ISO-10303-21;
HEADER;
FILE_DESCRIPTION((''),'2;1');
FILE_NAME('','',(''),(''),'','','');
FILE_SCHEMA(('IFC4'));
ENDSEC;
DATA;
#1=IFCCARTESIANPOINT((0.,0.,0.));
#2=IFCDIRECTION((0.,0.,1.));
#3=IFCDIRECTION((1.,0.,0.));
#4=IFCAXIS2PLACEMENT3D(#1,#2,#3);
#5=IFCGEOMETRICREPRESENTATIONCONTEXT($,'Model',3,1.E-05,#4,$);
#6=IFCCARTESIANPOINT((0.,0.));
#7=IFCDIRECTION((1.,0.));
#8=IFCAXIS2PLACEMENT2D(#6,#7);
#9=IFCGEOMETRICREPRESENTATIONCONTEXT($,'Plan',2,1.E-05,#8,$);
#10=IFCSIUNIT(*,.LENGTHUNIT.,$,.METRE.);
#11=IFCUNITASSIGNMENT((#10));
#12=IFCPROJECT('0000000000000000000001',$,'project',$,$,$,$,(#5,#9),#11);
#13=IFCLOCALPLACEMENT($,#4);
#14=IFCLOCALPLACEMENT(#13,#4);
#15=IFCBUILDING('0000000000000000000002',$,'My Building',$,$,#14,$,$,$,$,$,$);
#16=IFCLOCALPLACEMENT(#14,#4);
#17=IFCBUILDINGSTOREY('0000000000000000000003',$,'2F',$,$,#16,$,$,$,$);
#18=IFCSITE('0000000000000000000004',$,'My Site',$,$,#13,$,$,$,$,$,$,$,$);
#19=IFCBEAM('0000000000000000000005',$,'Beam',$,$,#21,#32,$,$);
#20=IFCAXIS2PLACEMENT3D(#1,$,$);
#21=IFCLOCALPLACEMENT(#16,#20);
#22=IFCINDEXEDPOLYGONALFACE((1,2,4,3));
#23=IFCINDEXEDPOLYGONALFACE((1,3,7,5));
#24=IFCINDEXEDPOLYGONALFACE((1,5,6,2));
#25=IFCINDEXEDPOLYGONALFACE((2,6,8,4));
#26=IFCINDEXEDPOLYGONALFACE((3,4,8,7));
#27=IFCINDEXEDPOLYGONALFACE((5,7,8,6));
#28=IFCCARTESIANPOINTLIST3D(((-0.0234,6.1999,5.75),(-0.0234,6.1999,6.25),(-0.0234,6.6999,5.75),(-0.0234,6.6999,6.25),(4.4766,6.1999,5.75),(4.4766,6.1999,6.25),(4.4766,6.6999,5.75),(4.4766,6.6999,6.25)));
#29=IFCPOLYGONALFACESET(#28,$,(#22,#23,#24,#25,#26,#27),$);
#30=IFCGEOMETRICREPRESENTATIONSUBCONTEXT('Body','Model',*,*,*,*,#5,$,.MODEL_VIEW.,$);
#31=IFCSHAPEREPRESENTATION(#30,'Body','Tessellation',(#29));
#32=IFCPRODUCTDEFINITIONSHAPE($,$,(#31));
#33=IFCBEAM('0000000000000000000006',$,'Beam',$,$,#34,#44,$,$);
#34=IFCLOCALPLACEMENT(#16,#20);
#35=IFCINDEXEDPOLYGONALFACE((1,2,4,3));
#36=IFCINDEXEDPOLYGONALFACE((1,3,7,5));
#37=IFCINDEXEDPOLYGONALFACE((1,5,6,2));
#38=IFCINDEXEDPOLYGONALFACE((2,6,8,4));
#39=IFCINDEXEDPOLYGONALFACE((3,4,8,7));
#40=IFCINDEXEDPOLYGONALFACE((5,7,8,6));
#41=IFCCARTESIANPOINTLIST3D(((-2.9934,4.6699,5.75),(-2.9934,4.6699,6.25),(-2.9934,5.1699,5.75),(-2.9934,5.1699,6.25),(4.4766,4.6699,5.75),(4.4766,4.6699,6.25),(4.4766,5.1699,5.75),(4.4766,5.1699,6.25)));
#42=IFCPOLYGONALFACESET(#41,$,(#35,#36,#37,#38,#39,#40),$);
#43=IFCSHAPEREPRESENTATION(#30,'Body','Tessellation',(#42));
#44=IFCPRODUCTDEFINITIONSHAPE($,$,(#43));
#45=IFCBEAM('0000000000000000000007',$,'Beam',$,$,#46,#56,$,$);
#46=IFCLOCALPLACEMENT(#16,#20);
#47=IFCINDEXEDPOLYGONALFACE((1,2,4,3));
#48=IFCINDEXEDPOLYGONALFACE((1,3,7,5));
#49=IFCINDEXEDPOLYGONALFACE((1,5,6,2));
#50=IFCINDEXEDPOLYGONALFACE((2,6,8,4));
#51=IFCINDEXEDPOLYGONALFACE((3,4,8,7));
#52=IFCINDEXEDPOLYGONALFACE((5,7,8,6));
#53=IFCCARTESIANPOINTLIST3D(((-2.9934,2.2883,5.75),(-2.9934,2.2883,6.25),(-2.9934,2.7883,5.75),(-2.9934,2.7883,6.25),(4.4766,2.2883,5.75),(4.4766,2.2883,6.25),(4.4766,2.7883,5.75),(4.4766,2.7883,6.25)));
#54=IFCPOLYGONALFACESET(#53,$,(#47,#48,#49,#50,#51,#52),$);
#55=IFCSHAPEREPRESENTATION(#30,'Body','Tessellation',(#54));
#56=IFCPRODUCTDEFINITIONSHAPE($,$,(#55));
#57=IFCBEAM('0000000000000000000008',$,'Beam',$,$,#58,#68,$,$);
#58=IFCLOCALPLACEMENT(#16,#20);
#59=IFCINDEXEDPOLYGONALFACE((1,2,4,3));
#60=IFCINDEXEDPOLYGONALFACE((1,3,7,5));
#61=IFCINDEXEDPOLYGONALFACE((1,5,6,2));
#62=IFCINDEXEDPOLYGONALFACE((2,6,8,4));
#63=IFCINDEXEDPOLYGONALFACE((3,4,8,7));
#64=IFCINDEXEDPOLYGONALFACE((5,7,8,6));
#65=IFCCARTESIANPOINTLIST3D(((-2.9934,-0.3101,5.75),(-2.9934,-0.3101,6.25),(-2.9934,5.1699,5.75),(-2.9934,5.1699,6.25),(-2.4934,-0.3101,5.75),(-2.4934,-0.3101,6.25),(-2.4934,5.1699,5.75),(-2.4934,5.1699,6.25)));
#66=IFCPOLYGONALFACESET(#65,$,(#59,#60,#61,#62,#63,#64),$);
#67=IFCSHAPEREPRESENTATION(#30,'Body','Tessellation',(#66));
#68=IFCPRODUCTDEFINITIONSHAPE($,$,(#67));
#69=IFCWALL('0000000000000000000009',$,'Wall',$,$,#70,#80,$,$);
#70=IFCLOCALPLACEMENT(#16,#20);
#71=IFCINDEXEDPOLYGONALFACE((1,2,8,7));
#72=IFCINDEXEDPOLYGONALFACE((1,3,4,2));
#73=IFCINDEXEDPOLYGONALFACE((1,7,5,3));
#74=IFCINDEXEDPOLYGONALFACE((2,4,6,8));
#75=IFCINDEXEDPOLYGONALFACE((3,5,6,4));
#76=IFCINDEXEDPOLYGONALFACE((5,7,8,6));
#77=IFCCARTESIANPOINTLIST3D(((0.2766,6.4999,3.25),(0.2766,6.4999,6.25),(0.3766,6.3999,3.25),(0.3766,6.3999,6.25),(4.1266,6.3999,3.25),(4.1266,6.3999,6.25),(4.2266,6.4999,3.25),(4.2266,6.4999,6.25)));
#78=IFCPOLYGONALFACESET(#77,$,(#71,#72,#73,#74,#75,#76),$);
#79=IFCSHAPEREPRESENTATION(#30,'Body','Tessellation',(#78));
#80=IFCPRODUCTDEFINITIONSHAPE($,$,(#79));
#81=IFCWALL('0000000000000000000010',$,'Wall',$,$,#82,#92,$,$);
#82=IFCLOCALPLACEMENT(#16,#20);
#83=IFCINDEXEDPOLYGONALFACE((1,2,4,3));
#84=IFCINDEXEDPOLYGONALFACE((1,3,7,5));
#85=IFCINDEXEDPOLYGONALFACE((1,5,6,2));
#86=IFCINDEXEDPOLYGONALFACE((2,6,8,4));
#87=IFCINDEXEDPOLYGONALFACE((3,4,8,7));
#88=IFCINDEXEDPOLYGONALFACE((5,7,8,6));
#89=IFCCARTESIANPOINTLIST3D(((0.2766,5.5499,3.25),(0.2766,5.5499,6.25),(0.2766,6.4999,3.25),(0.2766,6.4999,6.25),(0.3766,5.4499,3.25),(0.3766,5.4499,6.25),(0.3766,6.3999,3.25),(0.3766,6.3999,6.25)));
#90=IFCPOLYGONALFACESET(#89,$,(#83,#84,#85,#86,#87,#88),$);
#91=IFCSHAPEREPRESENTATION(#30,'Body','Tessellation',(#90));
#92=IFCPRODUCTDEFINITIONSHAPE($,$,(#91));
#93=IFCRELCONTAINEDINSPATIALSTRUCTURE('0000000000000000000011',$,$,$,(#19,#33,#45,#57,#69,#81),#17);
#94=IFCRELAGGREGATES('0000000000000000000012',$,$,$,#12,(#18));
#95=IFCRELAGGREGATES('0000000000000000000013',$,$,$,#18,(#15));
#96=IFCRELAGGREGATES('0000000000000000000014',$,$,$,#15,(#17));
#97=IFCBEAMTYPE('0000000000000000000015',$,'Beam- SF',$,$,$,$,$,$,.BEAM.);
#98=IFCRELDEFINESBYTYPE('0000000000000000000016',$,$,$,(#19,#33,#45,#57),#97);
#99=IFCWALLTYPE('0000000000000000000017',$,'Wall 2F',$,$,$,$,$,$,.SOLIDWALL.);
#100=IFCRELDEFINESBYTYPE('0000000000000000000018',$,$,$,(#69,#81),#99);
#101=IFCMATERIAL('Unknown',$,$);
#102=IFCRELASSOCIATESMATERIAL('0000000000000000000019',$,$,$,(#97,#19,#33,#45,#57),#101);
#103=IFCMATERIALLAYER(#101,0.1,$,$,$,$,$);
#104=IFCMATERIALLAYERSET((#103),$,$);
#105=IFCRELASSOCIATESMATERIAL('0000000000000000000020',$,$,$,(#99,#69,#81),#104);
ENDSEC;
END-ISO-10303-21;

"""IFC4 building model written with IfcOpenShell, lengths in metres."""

from ifc_helpers import new_model, si_unit, frame, origin_with_axes, origin_2d_with_axis, place, context, subcontext, project, spatial, line, indexed_curve, rectangle, outline, extrude, material, layer, layer_set, layer_usage, material_profile, profile_set, profile_usage, type_object, element, save


model = new_model("IFC4")

# Units and contexts
model_context = context("Model", 3, precision=1e-05, world=origin_with_axes())
plan_context = context("Plan", 2, precision=1e-05, world=origin_2d_with_axis())
body_context_1 = subcontext(model_context, "Body", "Model", "MODEL_VIEW")
ifc_project = project(units=[si_unit("LENGTHUNIT", "METRE")], contexts=[model_context, plan_context])

# Site, building, storey
site_placement = place(None, origin_with_axes())
site = spatial("IfcSite", under=ifc_project, at=site_placement, Name="My Site")
building_placement = place(site_placement, origin_with_axes())
building = spatial("IfcBuilding", under=site, at=building_placement, Name="My Building")
storey_placement = place(building_placement, origin_with_axes())
storey = spatial("IfcBuildingStorey", under=building, at=storey_placement, Name="2F")

# Beams
ifc_material = material(Name="Unknown")
ifc_material_profile = material_profile(ifc_material, rectangle(XDim=0.5, YDim=0.5))
ifc_profile_set = profile_set([ifc_material_profile])
ifc_profile_usage_1 = profile_usage(ifc_profile_set, cardinal=5)
beam_type = type_object("IfcBeamType", Name="Beam- SF", PredefinedType="BEAM", material=ifc_profile_set)
beam_1_placement = place(storey_placement, frame((4.4766, 6.4499, 6.0), z_axis=(-1.0, -0.000001, 0.000001), x_axis=(0.000001, -1.0, 0.0)))
element("IfcBeam", 1, at=beam_1_placement, inside=storey, type_object=beam_type, material=ifc_profile_usage_1, Name="Beam", context=body_context_1, shape_type="SweptSolid", body=[
    extrude(rectangle(XDim=0.5, YDim=0.5), origin_with_axes(), (0.0, 0.0, 1.0), 4.5),
])
ifc_profile_usage_2 = profile_usage(ifc_profile_set, cardinal=5)
beam_2_placement = place(storey_placement, frame((4.4766, 4.9199, 6.0), z_axis=(-1.0, -0.000001, 0.000001), x_axis=(0.000001, -1.0, 0.0)))
element("IfcBeam", 2, at=beam_2_placement, inside=storey, type_object=beam_type, material=ifc_profile_usage_2, Name="Beam", context=body_context_1, shape_type="SweptSolid", body=[
    extrude(rectangle(XDim=0.5, YDim=0.5), origin_with_axes(), (0.0, 0.0, 1.0), 7.47),
])
ifc_profile_usage_3 = profile_usage(ifc_profile_set, cardinal=5)
beam_3_placement = place(storey_placement, frame((4.4766, 2.5383, 6.0), z_axis=(-1.0, -0.000001, 0.000001), x_axis=(0.000001, -1.0, 0.0)))
element("IfcBeam", 3, at=beam_3_placement, inside=storey, type_object=beam_type, material=ifc_profile_usage_3, Name="Beam", context=body_context_1, shape_type="SweptSolid", body=[
    extrude(rectangle(XDim=0.5, YDim=0.5), origin_with_axes(), (0.0, 0.0, 1.0), 7.47),
])
ifc_profile_usage_4 = profile_usage(ifc_profile_set, cardinal=5)
beam_4_placement = place(storey_placement, frame((-2.7434, 5.1699, 6.0), z_axis=(0.0, -1.0, 0.0), x_axis=(1.0, 0.0, 0.0)))
element("IfcBeam", 4, at=beam_4_placement, inside=storey, type_object=beam_type, material=ifc_profile_usage_4, Name="Beam", context=body_context_1, shape_type="SweptSolid", body=[
    extrude(rectangle(XDim=0.5, YDim=0.5), origin_with_axes(), (0.0, 0.0, 1.0), 5.48),
])

# Walls
ifc_layer = layer(ifc_material, 0.1)
ifc_layer_set = layer_set([ifc_layer])
ifc_layer_usage_1 = layer_usage(ifc_layer_set, "AXIS2", "POSITIVE", 0.0)
wall_type = type_object("IfcWallType", Name="Wall 2F", PredefinedType="SOLIDWALL", material=ifc_layer_set)
wall_1_placement = place(storey_placement, frame((4.2266, 6.4999, 3.25), z_axis=(0.0, 0.0, 1.0), x_axis=(-1.0, 0.0, 0.0)))
element("IfcWall", 5, at=wall_1_placement, inside=storey, type_object=wall_type, material=ifc_layer_usage_1, Name="Wall", context=body_context_1, shape_type="SweptSolid", body=[
    extrude(outline(indexed_curve([(0.0, 0.0), (0.1, 0.1), (3.85, 0.1), (3.95, 0.0)], segments=[line(1, 2, 3, 4, 1)])), origin_with_axes(), (0.0, 0.0, 1.0), 3.0),
])
ifc_layer_usage_2 = layer_usage(ifc_layer_set, "AXIS2", "POSITIVE", 0.0)
wall_2_placement = place(storey_placement, frame((0.2766, 6.4999, 3.25), z_axis=(0.0, 0.0, 1.0), x_axis=(0.0, -1.0, 0.0)))
element("IfcWall", 6, at=wall_2_placement, inside=storey, type_object=wall_type, material=ifc_layer_usage_2, Name="Wall", context=body_context_1, shape_type="SweptSolid", body=[
    extrude(outline(indexed_curve([(0.0, 0.0), (0.1, 0.1), (1.05, 0.1), (0.95, 0.0)], segments=[line(1, 2, 3, 4, 1)])), origin_with_axes(), (0.0, 0.0, 1.0), 3.0),
])

save(model, "model.ifc")
